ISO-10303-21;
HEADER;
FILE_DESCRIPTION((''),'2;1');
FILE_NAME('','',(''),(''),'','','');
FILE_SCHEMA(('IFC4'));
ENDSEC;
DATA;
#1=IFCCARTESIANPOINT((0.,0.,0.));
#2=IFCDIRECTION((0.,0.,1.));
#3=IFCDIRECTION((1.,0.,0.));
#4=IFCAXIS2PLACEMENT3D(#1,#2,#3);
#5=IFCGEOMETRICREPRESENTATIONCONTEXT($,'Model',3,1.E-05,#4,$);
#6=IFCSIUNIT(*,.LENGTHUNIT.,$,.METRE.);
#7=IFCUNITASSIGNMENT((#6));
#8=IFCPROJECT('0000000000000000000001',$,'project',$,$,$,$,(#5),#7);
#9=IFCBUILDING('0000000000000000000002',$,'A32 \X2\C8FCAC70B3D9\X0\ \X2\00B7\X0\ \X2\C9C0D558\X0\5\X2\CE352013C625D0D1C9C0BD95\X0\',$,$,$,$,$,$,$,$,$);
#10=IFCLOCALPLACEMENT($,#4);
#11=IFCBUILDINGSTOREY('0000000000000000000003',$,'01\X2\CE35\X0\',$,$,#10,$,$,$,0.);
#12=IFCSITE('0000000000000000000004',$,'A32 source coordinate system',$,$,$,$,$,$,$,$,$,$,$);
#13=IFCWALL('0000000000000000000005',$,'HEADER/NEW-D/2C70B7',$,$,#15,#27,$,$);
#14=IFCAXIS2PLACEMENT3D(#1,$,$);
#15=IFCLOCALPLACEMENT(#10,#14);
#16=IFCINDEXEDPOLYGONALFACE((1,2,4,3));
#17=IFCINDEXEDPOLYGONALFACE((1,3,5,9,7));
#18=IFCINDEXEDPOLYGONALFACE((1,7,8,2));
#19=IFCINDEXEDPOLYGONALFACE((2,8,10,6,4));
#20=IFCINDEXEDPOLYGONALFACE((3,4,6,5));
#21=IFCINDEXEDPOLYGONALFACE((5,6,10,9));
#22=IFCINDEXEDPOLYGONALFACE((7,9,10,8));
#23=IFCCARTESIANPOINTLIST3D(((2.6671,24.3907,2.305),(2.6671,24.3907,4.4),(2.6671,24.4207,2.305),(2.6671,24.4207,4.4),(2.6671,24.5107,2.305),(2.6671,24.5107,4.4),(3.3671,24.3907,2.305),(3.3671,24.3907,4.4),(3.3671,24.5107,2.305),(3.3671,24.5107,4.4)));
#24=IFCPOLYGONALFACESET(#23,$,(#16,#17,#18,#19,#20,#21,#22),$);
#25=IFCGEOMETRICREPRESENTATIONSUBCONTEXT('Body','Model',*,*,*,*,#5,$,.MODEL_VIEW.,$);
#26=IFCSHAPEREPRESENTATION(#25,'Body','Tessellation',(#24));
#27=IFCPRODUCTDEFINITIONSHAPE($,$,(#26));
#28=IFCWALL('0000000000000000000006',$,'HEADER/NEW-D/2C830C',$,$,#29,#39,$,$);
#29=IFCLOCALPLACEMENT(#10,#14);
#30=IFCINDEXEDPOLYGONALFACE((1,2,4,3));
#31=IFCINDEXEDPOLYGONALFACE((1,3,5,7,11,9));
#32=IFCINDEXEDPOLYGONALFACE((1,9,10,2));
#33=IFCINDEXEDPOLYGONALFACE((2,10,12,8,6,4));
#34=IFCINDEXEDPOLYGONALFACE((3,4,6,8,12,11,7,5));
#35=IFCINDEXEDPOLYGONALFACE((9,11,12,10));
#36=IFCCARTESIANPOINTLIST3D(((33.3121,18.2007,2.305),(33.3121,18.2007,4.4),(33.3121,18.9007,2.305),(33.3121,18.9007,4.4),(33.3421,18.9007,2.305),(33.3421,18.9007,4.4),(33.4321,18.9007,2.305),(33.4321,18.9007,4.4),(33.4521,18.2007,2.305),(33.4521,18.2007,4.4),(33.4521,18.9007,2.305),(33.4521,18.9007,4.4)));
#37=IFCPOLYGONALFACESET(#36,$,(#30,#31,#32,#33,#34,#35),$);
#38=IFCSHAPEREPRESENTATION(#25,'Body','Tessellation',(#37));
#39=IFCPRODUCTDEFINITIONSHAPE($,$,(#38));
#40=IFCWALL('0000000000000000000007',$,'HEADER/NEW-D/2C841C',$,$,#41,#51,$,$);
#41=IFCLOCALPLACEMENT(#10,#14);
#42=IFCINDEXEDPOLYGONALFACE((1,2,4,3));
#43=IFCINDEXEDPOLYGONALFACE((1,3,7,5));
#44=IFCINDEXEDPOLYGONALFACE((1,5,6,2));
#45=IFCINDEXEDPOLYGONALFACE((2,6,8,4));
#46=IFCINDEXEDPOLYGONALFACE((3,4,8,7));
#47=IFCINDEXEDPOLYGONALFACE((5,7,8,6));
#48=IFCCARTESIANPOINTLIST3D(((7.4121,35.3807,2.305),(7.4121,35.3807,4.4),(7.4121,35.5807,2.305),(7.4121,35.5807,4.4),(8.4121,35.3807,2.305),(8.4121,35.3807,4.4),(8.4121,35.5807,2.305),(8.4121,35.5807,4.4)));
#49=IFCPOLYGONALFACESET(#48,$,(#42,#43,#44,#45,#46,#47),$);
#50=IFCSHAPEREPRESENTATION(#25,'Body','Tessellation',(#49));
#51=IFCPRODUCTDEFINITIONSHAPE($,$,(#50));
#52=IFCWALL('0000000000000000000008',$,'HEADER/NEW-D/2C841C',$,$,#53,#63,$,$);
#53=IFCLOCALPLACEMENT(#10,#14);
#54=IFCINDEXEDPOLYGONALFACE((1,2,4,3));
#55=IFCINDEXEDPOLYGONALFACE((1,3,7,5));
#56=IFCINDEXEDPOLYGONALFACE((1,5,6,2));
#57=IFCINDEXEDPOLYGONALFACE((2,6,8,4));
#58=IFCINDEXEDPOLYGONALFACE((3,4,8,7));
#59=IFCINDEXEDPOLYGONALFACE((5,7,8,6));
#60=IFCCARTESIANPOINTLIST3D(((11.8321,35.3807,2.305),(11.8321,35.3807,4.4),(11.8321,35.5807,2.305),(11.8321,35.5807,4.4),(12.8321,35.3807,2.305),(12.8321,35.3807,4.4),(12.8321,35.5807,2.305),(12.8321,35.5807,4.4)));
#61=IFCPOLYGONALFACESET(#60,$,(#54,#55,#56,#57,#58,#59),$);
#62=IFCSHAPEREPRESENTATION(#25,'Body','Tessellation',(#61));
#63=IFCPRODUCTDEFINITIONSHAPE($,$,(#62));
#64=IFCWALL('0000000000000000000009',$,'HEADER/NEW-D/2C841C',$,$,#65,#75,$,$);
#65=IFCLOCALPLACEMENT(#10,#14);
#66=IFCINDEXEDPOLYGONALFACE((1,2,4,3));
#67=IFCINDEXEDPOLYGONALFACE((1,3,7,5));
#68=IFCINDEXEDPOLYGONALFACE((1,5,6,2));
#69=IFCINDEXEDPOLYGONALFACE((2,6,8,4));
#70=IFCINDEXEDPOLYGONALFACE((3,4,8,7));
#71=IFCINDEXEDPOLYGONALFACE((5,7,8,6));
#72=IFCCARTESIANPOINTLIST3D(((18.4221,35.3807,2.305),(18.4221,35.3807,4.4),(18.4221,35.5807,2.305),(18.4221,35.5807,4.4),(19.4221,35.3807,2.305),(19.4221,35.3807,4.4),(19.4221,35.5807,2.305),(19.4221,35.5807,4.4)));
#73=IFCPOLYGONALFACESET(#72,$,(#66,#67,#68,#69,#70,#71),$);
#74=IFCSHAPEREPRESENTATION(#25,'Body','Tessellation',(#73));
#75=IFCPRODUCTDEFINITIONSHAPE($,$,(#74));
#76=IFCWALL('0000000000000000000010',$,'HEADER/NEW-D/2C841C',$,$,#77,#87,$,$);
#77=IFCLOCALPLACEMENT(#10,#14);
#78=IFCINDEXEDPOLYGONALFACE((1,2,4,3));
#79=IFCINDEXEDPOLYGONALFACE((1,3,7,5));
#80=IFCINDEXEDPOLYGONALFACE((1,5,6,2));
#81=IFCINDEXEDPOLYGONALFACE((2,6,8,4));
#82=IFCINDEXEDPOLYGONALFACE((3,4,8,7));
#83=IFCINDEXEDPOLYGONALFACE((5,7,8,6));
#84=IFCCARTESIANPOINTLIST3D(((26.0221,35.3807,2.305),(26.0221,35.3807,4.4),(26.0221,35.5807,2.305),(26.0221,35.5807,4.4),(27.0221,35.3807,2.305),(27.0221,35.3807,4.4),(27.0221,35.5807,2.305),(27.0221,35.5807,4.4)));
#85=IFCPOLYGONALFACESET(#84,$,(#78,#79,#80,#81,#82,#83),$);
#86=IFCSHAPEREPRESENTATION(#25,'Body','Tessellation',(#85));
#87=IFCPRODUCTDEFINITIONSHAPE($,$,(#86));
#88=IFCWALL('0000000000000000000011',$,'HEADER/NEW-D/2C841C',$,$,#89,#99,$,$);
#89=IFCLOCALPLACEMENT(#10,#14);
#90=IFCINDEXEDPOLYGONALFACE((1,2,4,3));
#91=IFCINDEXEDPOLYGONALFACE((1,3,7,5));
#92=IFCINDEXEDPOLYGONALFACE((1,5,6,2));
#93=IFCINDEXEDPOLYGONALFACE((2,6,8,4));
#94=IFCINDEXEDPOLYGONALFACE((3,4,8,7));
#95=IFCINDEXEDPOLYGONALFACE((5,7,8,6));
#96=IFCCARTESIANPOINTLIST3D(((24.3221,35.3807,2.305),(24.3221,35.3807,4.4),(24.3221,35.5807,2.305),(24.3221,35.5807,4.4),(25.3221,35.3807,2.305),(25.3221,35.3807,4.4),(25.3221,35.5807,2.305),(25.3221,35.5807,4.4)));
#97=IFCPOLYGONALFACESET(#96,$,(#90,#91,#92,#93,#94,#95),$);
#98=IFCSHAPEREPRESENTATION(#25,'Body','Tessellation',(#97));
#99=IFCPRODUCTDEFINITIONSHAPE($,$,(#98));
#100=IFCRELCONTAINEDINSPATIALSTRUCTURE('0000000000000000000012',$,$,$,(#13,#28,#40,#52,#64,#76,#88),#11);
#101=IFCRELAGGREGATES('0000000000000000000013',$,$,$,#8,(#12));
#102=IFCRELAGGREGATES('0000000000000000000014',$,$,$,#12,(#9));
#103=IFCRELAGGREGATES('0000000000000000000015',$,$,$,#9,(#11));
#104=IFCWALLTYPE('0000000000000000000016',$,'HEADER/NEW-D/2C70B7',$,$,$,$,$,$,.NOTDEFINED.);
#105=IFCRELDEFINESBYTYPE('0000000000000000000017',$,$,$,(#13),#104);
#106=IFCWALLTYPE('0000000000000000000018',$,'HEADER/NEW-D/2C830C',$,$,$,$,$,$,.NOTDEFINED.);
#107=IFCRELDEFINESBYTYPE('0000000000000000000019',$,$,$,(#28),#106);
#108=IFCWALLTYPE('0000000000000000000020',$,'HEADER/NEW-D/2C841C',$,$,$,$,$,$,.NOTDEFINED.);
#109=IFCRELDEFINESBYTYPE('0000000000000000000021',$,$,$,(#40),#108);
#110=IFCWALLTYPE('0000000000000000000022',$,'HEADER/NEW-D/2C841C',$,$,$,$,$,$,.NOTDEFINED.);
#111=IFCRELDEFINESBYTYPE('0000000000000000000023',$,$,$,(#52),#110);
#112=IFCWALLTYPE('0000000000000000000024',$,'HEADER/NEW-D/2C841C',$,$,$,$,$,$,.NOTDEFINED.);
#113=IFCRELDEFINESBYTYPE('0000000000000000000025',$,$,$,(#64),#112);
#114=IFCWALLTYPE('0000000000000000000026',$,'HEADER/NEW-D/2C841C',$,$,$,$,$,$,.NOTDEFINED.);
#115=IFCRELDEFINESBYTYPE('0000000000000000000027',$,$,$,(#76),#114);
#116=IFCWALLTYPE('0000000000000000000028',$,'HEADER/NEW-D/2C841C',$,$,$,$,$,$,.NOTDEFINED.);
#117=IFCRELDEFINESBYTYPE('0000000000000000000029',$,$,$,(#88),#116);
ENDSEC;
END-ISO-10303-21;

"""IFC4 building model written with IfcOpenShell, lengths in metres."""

from ifc_helpers import new_model, si_unit, frame, origin, origin_with_axes, place, context, subcontext, project, spatial, polyline, outline, extrude, source, transform, mapped, type_object, type_shapes, element, save


model = new_model("IFC4")

# Units and contexts
model_context = context("Model", 3, precision=1e-05, world=origin_with_axes())
body_context = subcontext(model_context, "Body", "Model", "MODEL_VIEW")
ifc_project = project(units=[si_unit("LENGTHUNIT", "METRE")], contexts=[model_context])

# Site, building, storey
site = spatial("IfcSite", under=ifc_project, Name="A32 source coordinate system")
building = spatial("IfcBuilding", under=site, Name="A32 주거동 · 지하5층–옥탑지붕")
storey_placement = place(None, origin_with_axes())
storey = spatial("IfcBuildingStorey", under=building, at=storey_placement, Name="01층", Elevation=0.0)

# Walls
wall_type_1 = type_object("IfcWallType", Name="HEADER/NEW-D/2C70B7", PredefinedType="NOTDEFINED")
shared_shape_1 = source(origin(), body_context, "Body", "SweptSolid", [
    extrude(outline(polyline([(2.6671, 24.5107), (3.3671, 24.5107), (3.3671, 24.3907), (2.6671, 24.3907), (2.6671, 24.4207), (2.6671, 24.4207), (2.6671, 24.5107)])), frame((0.0, 0.0, 2.305)), (0.0, 0.0, 1.0), 2.095),
])
type_shapes(wall_type_1, [shared_shape_1])
wall_1_placement = place(storey_placement, origin_with_axes())
element("IfcWall", 1, at=wall_1_placement, inside=storey, type_object=wall_type_1, Name="HEADER/NEW-D/2C70B7", context=body_context, shape_type="MappedRepresentation", body=[
    mapped(shared_shape_1, transform((0.0, 0.0, 0.0), scale=1.0)),
])
wall_type_2 = type_object("IfcWallType", Name="HEADER/NEW-D/2C830C", PredefinedType="NOTDEFINED")
shared_shape_2 = source(origin(), body_context, "Body", "SweptSolid", [
    extrude(outline(polyline([(33.4521, 18.9007), (33.4521, 18.2007), (33.3121, 18.2007), (33.3121, 18.9007), (33.3421, 18.9007), (33.3421, 18.9007), (33.4321, 18.9007), (33.4321, 18.9007), (33.4521, 18.9007)])), frame((0.0, 0.0, 2.305)), (0.0, 0.0, 1.0), 2.095),
])
type_shapes(wall_type_2, [shared_shape_2])
wall_2_placement = place(storey_placement, origin_with_axes())
element("IfcWall", 2, at=wall_2_placement, inside=storey, type_object=wall_type_2, Name="HEADER/NEW-D/2C830C", context=body_context, shape_type="MappedRepresentation", body=[
    mapped(shared_shape_2, transform((0.0, 0.0, 0.0), scale=1.0)),
])
wall_type_3 = type_object("IfcWallType", Name="HEADER/NEW-D/2C841C", PredefinedType="NOTDEFINED")
shared_shape_3 = source(origin(), body_context, "Body", "SweptSolid", [
    extrude(outline(polyline([(7.4121, 35.3807), (7.4121, 35.5807), (8.4121, 35.5807), (8.4121, 35.3807), (7.4121, 35.3807)])), frame((0.0, 0.0, 2.305)), (0.0, 0.0, 1.0), 2.095),
])
type_shapes(wall_type_3, [shared_shape_3])
wall_3_placement = place(storey_placement, origin_with_axes())
element("IfcWall", 3, at=wall_3_placement, inside=storey, type_object=wall_type_3, Name="HEADER/NEW-D/2C841C", context=body_context, shape_type="MappedRepresentation", body=[
    mapped(shared_shape_3, transform((0.0, 0.0, 0.0), scale=1.0)),
])
wall_type_4 = type_object("IfcWallType", Name="HEADER/NEW-D/2C841C", PredefinedType="NOTDEFINED")
shared_shape_4 = source(origin(), body_context, "Body", "SweptSolid", [
    extrude(outline(polyline([(11.8321, 35.3807), (11.8321, 35.5807), (12.8321, 35.5807), (12.8321, 35.3807), (11.8321, 35.3807)])), frame((0.0, 0.0, 2.305)), (0.0, 0.0, 1.0), 2.095),
])
type_shapes(wall_type_4, [shared_shape_4])
wall_4_placement = place(storey_placement, origin_with_axes())
element("IfcWall", 4, at=wall_4_placement, inside=storey, type_object=wall_type_4, Name="HEADER/NEW-D/2C841C", context=body_context, shape_type="MappedRepresentation", body=[
    mapped(shared_shape_4, transform((0.0, 0.0, 0.0), scale=1.0)),
])
wall_type_5 = type_object("IfcWallType", Name="HEADER/NEW-D/2C841C", PredefinedType="NOTDEFINED")
shared_shape_5 = source(origin(), body_context, "Body", "SweptSolid", [
    extrude(outline(polyline([(18.4221, 35.3807), (18.4221, 35.5807), (19.4221, 35.5807), (19.4221, 35.3807), (18.4221, 35.3807)])), frame((0.0, 0.0, 2.305)), (0.0, 0.0, 1.0), 2.095),
])
type_shapes(wall_type_5, [shared_shape_5])
wall_5_placement = place(storey_placement, origin_with_axes())
element("IfcWall", 5, at=wall_5_placement, inside=storey, type_object=wall_type_5, Name="HEADER/NEW-D/2C841C", context=body_context, shape_type="MappedRepresentation", body=[
    mapped(shared_shape_5, transform((0.0, 0.0, 0.0), scale=1.0)),
])
wall_type_6 = type_object("IfcWallType", Name="HEADER/NEW-D/2C841C", PredefinedType="NOTDEFINED")
shared_shape_6 = source(origin(), body_context, "Body", "SweptSolid", [
    extrude(outline(polyline([(26.0221, 35.3807), (26.0221, 35.5807), (27.0221, 35.5807), (27.0221, 35.3807), (26.0221, 35.3807)])), frame((0.0, 0.0, 2.305)), (0.0, 0.0, 1.0), 2.095),
])
type_shapes(wall_type_6, [shared_shape_6])
wall_6_placement = place(storey_placement, origin_with_axes())
element("IfcWall", 6, at=wall_6_placement, inside=storey, type_object=wall_type_6, Name="HEADER/NEW-D/2C841C", context=body_context, shape_type="MappedRepresentation", body=[
    mapped(shared_shape_6, transform((0.0, 0.0, 0.0), scale=1.0)),
])
wall_type_7 = type_object("IfcWallType", Name="HEADER/NEW-D/2C841C", PredefinedType="NOTDEFINED")
shared_shape_7 = source(origin(), body_context, "Body", "SweptSolid", [
    extrude(outline(polyline([(24.3221, 35.3807), (24.3221, 35.5807), (25.3221, 35.5807), (25.3221, 35.3807), (24.3221, 35.3807)])), frame((0.0, 0.0, 2.305)), (0.0, 0.0, 1.0), 2.095),
])
type_shapes(wall_type_7, [shared_shape_7])
wall_7_placement = place(storey_placement, origin_with_axes())
element("IfcWall", 7, at=wall_7_placement, inside=storey, type_object=wall_type_7, Name="HEADER/NEW-D/2C841C", context=body_context, shape_type="MappedRepresentation", body=[
    mapped(shared_shape_7, transform((0.0, 0.0, 0.0), scale=1.0)),
])

save(model, "model.ifc")
